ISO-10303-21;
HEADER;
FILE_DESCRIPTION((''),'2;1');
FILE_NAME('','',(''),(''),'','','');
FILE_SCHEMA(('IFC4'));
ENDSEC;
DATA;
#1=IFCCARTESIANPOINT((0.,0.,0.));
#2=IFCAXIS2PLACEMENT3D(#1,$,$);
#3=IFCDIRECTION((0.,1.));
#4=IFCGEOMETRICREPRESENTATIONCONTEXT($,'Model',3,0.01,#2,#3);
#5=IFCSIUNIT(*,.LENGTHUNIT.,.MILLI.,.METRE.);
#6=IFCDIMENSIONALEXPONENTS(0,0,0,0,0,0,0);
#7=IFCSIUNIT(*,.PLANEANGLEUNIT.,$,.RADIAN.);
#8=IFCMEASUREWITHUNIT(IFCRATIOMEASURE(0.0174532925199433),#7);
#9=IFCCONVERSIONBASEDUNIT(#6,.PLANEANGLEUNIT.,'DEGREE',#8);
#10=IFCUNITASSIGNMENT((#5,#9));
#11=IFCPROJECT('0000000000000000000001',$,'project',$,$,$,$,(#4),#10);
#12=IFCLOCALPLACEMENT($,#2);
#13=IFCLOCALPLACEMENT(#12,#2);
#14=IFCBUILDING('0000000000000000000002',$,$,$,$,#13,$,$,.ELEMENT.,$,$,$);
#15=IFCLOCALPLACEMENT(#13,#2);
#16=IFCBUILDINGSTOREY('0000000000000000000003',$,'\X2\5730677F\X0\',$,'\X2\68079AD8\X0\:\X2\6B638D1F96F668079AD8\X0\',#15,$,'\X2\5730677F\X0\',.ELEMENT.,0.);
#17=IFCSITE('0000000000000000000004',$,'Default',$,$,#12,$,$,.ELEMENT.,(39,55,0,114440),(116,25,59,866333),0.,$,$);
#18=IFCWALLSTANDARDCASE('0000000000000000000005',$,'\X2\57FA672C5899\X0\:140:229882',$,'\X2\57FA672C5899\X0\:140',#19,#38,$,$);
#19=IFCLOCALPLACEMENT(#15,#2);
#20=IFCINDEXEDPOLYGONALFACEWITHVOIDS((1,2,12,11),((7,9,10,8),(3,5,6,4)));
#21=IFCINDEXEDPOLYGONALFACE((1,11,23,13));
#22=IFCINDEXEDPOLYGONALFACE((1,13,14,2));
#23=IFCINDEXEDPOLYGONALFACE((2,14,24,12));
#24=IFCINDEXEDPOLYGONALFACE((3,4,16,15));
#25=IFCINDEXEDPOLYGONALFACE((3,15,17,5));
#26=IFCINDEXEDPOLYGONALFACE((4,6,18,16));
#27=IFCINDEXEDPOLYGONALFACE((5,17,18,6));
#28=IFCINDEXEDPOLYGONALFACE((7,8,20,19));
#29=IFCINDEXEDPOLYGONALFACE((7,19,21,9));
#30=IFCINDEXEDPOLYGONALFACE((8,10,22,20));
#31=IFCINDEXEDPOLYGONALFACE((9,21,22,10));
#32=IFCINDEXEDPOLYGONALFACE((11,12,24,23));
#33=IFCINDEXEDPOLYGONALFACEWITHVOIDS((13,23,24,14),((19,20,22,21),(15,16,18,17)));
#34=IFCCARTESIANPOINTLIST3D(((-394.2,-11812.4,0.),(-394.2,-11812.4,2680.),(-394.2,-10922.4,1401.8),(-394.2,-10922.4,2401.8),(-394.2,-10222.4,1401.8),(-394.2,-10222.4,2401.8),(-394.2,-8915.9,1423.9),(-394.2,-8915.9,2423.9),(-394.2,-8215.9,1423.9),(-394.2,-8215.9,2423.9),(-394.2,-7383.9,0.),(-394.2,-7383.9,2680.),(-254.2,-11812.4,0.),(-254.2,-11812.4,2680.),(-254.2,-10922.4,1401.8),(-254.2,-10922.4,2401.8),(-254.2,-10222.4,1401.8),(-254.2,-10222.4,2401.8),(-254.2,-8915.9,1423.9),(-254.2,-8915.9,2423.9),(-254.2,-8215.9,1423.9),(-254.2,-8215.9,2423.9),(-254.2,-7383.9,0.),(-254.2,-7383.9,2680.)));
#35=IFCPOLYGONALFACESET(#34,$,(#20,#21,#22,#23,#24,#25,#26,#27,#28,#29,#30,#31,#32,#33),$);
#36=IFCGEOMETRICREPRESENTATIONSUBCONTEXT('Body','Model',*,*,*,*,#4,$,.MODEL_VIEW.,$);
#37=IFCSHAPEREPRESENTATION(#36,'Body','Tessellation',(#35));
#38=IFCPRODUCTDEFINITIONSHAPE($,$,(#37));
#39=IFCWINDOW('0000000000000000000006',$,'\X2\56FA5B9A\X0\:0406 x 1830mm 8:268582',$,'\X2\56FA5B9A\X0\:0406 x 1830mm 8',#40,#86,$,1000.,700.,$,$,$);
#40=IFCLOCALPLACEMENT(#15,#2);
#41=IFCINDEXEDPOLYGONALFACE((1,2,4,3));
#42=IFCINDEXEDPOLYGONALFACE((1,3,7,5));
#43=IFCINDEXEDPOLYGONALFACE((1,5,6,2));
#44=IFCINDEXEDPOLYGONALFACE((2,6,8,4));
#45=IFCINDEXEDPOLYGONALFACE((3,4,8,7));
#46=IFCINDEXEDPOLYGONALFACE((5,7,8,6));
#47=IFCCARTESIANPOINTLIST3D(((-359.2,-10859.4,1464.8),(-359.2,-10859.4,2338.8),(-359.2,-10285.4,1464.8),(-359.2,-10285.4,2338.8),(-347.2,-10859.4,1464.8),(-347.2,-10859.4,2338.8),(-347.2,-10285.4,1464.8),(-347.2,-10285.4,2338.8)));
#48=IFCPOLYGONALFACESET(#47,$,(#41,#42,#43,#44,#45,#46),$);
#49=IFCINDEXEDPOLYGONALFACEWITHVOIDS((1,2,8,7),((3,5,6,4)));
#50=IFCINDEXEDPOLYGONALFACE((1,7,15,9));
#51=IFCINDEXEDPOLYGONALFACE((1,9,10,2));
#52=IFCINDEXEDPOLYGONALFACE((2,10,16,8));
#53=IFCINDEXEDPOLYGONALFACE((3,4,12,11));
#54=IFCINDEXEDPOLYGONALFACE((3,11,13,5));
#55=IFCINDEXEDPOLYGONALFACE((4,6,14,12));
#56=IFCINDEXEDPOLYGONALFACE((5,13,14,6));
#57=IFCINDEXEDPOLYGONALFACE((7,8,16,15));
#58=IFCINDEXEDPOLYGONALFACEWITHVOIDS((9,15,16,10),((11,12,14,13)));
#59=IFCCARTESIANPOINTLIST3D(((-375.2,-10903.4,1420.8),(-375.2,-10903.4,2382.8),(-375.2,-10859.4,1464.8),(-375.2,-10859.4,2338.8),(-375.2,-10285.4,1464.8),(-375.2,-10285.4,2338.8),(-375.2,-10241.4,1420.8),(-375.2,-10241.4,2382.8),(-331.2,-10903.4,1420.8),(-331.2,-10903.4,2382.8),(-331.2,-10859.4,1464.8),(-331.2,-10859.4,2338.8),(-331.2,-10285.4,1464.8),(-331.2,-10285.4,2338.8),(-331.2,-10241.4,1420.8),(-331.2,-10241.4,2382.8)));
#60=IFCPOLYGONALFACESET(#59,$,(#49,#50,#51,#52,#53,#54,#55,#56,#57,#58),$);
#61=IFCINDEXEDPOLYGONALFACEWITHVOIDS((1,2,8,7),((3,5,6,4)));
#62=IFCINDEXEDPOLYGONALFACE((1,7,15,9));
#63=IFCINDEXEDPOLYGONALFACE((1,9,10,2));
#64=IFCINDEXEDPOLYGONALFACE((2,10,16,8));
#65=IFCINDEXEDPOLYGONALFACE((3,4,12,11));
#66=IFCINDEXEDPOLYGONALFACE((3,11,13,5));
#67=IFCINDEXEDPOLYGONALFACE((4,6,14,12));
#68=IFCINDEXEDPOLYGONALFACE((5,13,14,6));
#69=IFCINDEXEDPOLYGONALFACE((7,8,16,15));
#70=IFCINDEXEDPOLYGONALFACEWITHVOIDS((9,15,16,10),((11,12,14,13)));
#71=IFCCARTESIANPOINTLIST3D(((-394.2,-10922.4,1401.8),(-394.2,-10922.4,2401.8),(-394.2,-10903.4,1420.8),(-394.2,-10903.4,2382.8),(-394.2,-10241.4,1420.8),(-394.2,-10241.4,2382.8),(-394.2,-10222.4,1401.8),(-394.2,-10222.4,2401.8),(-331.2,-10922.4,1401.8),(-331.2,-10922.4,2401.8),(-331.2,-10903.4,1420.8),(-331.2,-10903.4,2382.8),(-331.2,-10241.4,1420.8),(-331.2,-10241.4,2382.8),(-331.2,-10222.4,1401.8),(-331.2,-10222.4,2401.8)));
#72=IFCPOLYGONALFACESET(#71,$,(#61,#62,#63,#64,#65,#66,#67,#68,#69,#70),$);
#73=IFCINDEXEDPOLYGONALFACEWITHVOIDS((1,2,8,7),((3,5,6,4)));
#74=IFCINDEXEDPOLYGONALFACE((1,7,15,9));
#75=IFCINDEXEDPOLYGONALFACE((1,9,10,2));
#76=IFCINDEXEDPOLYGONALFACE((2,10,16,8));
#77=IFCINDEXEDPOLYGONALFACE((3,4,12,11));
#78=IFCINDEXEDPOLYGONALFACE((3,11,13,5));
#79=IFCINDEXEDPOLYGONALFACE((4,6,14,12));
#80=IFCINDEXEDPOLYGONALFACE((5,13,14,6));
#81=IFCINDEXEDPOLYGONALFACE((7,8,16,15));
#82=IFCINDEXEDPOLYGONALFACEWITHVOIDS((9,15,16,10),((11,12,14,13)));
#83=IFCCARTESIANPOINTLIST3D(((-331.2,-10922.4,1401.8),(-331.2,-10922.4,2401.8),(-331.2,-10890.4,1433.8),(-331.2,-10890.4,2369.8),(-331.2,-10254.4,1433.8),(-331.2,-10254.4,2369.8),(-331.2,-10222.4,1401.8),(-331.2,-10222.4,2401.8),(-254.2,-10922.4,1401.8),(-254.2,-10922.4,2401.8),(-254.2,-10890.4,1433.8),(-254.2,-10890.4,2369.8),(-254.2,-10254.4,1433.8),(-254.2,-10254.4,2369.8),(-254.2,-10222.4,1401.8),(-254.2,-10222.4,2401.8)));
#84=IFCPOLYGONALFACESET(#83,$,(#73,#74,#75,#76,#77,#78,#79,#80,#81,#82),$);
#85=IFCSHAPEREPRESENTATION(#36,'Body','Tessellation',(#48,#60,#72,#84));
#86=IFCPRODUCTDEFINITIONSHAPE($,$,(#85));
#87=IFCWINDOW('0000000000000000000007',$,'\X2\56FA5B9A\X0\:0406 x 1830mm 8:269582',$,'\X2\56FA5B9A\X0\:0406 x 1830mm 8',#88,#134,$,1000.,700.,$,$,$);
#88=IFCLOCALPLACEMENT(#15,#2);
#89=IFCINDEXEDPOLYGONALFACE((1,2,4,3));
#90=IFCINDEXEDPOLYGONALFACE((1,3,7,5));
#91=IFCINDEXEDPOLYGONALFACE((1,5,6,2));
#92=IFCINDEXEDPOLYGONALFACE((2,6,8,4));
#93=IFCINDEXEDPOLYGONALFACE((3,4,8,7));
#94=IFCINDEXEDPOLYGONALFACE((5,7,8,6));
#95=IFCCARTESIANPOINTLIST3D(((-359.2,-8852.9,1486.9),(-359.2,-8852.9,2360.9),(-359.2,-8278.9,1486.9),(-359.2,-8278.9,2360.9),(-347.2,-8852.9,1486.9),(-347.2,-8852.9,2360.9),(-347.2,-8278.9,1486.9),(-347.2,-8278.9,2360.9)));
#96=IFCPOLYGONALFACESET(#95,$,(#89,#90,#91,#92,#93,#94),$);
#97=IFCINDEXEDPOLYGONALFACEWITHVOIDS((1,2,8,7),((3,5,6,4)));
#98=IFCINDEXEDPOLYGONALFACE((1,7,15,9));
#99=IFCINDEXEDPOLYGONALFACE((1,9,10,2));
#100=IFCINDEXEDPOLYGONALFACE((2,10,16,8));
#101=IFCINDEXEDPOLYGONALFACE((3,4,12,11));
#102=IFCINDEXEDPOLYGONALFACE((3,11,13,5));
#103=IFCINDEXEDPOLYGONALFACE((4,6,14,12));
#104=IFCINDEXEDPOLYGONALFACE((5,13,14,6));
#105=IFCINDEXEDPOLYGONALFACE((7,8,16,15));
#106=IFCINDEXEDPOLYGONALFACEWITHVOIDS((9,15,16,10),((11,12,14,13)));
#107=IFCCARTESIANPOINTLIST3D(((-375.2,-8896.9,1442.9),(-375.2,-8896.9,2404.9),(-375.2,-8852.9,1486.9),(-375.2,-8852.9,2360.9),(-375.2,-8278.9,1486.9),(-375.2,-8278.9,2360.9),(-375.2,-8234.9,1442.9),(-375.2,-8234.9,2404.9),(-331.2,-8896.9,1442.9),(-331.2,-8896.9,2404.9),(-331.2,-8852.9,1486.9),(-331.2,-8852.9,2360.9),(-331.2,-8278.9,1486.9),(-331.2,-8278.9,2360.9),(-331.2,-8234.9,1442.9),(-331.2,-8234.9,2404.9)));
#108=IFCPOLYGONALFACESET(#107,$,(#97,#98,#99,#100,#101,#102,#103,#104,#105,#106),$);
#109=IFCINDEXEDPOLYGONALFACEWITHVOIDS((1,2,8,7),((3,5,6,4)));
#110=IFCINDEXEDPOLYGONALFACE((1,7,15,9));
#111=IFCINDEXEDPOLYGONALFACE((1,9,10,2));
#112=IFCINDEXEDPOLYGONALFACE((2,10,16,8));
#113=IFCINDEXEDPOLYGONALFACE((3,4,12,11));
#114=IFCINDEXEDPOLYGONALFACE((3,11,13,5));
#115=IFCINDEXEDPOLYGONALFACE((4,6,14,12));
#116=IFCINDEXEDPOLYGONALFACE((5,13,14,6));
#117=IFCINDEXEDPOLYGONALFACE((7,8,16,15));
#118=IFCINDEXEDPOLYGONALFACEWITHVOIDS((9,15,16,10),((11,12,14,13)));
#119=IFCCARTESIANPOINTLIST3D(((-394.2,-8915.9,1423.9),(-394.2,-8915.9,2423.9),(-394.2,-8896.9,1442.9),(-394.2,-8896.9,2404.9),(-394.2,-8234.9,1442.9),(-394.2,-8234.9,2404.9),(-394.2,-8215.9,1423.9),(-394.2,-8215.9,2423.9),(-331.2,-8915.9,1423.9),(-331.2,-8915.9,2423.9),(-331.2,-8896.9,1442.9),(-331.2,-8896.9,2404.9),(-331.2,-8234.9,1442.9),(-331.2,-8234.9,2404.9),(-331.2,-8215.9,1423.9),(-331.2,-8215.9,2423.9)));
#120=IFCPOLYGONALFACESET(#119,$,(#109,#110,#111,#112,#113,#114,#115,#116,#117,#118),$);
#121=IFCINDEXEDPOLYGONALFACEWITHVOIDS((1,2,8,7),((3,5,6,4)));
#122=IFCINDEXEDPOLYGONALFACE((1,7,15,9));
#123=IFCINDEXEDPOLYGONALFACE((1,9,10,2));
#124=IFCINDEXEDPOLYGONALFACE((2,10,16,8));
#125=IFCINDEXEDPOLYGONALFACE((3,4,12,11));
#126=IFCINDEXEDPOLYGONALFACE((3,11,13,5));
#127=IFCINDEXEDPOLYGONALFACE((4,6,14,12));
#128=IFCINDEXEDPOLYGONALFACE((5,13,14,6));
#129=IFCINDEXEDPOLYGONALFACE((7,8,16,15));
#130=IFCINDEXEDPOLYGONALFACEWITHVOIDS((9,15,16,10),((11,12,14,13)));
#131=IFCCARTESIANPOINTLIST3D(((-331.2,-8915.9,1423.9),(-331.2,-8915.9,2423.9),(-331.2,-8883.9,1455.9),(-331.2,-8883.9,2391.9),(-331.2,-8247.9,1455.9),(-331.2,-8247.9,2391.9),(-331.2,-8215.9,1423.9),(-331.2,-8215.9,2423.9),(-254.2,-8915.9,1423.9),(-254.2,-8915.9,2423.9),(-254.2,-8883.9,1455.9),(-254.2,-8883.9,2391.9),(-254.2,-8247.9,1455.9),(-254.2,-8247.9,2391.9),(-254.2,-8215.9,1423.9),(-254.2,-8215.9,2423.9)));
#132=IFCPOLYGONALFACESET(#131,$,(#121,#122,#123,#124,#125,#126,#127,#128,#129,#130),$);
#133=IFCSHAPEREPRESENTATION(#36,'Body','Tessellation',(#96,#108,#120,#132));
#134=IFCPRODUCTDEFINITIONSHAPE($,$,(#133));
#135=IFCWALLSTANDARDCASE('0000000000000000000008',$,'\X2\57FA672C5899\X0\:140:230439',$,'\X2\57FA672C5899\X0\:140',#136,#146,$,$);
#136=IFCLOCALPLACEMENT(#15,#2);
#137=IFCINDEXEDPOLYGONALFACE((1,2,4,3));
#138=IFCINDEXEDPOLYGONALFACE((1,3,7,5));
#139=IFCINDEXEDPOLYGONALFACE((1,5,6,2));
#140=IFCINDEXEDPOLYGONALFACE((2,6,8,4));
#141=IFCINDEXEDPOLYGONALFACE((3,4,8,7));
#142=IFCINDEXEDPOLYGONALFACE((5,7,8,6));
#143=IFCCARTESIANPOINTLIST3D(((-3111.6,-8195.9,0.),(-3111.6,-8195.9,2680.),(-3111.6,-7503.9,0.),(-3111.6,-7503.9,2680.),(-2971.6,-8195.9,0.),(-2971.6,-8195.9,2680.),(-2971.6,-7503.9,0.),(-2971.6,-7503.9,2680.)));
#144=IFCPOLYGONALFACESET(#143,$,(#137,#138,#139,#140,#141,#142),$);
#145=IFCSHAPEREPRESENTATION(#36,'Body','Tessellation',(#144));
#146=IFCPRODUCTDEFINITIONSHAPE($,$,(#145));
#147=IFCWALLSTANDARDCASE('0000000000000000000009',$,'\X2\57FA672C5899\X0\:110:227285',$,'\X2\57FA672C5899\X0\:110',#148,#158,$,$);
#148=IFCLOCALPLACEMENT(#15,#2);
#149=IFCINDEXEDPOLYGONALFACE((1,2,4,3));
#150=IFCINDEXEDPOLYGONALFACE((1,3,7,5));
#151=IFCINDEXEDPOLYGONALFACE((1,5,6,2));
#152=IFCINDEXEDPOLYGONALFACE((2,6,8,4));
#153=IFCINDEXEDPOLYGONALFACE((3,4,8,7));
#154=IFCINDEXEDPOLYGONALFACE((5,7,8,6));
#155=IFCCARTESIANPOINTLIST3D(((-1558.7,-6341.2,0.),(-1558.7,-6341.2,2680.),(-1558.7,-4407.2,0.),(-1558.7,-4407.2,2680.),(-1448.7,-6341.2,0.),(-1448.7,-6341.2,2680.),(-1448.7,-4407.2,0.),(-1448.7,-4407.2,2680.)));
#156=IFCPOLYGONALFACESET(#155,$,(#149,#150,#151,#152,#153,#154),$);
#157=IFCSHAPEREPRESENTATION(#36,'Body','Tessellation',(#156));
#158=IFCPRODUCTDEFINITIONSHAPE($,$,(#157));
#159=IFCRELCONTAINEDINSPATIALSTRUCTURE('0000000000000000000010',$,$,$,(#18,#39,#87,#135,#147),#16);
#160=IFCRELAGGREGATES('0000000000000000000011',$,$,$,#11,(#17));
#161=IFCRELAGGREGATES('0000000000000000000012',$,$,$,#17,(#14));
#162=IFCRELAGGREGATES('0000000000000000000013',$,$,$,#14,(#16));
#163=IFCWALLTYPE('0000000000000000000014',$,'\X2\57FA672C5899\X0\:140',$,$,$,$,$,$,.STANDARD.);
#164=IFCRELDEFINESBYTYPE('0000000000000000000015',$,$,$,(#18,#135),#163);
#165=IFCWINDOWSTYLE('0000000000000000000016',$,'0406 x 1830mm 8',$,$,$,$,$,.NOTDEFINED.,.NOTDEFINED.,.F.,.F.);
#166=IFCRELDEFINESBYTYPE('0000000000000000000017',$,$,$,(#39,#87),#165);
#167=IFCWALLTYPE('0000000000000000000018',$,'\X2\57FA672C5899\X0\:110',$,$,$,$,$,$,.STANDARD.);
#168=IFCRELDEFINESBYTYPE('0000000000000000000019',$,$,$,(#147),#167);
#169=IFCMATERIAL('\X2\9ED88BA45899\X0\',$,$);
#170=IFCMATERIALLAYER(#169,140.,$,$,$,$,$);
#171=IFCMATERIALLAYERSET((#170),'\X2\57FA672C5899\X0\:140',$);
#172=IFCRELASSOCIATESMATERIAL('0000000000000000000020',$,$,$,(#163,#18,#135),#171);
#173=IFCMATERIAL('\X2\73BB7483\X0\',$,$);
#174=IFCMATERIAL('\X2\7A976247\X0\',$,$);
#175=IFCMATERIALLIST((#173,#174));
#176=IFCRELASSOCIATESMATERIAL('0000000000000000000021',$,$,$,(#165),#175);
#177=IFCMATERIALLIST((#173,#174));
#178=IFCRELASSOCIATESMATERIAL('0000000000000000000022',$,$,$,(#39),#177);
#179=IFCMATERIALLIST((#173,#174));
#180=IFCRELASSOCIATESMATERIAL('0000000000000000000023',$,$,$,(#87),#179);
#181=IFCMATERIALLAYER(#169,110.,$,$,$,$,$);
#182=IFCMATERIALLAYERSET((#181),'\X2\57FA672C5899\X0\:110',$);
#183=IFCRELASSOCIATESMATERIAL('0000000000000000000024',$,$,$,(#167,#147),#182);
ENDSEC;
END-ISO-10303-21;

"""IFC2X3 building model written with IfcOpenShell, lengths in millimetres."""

from ifc_helpers import new_model, entity, si_unit, converted_unit, direction, frame, frame_2d, origin, origin_2d_with_axis, place, context, subcontext, project, spatial, polyline, rectangle, outline, extrude, source, transform, mapped, material, material_list, layer, layer_set, layer_usage, type_object, type_shapes, element, fill, save


model = new_model("IFC2X3")

# Units and contexts
model_context = context("Model", 3, precision=0.01, world=origin(), true_north=direction((0.0, 1.0)))
body_context = subcontext(model_context, "Body", "Model", "MODEL_VIEW")
ifc_project = project(units=[si_unit("LENGTHUNIT", "METRE", prefix="MILLI"), converted_unit("PLANEANGLEUNIT", "DEGREE", entity("IfcRatioMeasure", 0.0174532925199433), si_unit("PLANEANGLEUNIT", "RADIAN"), dimensions=[0, 0, 0, 0, 0, 0, 0])], contexts=[model_context])

# Site, building, storey
site_placement = place(None, origin())
site = spatial("IfcSite", under=ifc_project, at=site_placement, Name="Default", CompositionType="ELEMENT", RefLatitude=(39, 55, 0, 114440), RefLongitude=(116, 25, 59, 866333), RefElevation=0.0)
building_placement = place(site_placement, origin())
building = spatial("IfcBuilding", under=site, at=building_placement, CompositionType="ELEMENT")
storey_placement = place(building_placement, origin())
storey = spatial("IfcBuildingStorey", under=building, at=storey_placement, Name="地板", ObjectType="标高:正负零标高", LongName="地板", CompositionType="ELEMENT", Elevation=0.0)

# Shared definitions
ifc_material_1 = material(Name="默认墙")

# Shared definitions
ifc_material_2 = material(Name="玻璃")
ifc_material_3 = material(Name="窗扇")

# Shared definitions
ifc_layer_1 = layer(ifc_material_1, 140.0)
ifc_layer_set_1 = layer_set([ifc_layer_1], Name="基本墙:140")
wall_type_1 = type_object("IfcWallType", Name="基本墙:140", PredefinedType="STANDARD", material=ifc_layer_set_1)

# Wall, openings, windows
ifc_layer_usage_1 = layer_usage(ifc_layer_set_1, "AXIS2", "NEGATIVE", 70.0)
wall_1_placement = place(storey_placement, frame((-324.2, -11812.4, 0.0), z_axis=(0.0, 0.0, 1.0), x_axis=(0.0, 1.0, 0.0)))
wall_1 = element("IfcWallStandardCase", 1, at=wall_1_placement, inside=storey, type_object=wall_type_1, material=ifc_layer_usage_1, Name="基本墙:140:229882", ObjectType="基本墙:140", context=body_context, shape_type="SweptSolid", body=[
    extrude(rectangle(XDim=4428.5, YDim=140.0, at=frame_2d((2214.3, 0.0), x_axis=(-1.0, 0.0))), origin(), (0.0, 0.0, 1.0), 2680.0),
])
opening_1_placement = place(wall_1_placement, frame((890.0, -70.0, 1401.8)))
opening_1 = element("IfcOpeningElement", 2, at=opening_1_placement, cuts=wall_1, ObjectType="Opening", context=body_context, shape_type="SweptSolid", body=[
    extrude(rectangle(XDim=1000.0, YDim=700.0, at=frame_2d((500.0, 350.0), x_axis=(1.0, 0.0))), frame((0.0, 0.0, 0.0), z_axis=(0.0, 1.0, 0.0), x_axis=(0.0, 0.0, 1.0)), (0.0, 0.0, 1.0), 140.0),
])
opening_2_placement = place(wall_1_placement, frame((2896.5, -70.0, 1423.9)))
opening_2 = element("IfcOpeningElement", 3, at=opening_2_placement, cuts=wall_1, ObjectType="Opening", context=body_context, shape_type="SweptSolid", body=[
    extrude(rectangle(XDim=1000.0, YDim=700.0, at=frame_2d((500.0, 350.0), x_axis=(1.0, 0.0))), frame((0.0, 0.0, 0.0), z_axis=(0.0, 1.0, 0.0), x_axis=(0.0, 0.0, 1.0)), (0.0, 0.0, 1.0), 140.0),
])
ifc_material_list_1 = material_list([ifc_material_2, ifc_material_3])
ifc_material_list_2 = material_list([ifc_material_2, ifc_material_3])
window_style_1 = type_object("IfcWindowStyle", Name="0406 x 1830mm 8", ConstructionType="NOTDEFINED", OperationType="NOTDEFINED", ParameterTakesPrecedence=False, Sizeable=False, material=ifc_material_list_2)
shared_shape_1 = source(origin(), body_context, "Body", "SweptSolid", [
    extrude(rectangle(XDim=12.0, YDim=574.0, at=origin_2d_with_axis()), frame((350.0, 99.0, 63.0), z_axis=(0.0, 0.0, 1.0), x_axis=(0.0, -1.0, 0.0)), (0.0, 0.0, 1.0), 874.0),
    extrude(outline(polyline([(-331.0, -481.0), (331.0, -481.0), (331.0, 481.0), (-331.0, 481.0), (-331.0, -481.0)]), holes=[polyline([(-287.0, -437.0), (-287.0, 437.0), (287.0, 437.0), (287.0, -437.0), (-287.0, -437.0)])]), frame((350.0, 77.0, 500.0), z_axis=(0.0, 1.0, 0.0), x_axis=(1.0, 0.0, 0.0)), (0.0, 0.0, 1.0), 44.0),
    extrude(outline(polyline([(-350.0, -500.0), (350.0, -500.0), (350.0, 500.0), (-350.0, 500.0), (-350.0, -500.0)]), holes=[polyline([(-331.0, -481.0), (-331.0, 481.0), (331.0, 481.0), (331.0, -481.0), (-331.0, -481.0)])]), frame((350.0, 77.0, 500.0), z_axis=(0.0, 1.0, 0.0), x_axis=(1.0, 0.0, 0.0)), (0.0, 0.0, 1.0), 63.0),
    extrude(outline(polyline([(-350.0, -500.0), (350.0, -500.0), (350.0, 500.0), (-350.0, 500.0), (-350.0, -500.0)]), holes=[polyline([(-318.0, -468.0), (-318.0, 468.0), (318.0, 468.0), (318.0, -468.0), (-318.0, -468.0)])]), frame((350.0, 0.0, 500.0), z_axis=(0.0, 1.0, 0.0), x_axis=(1.0, 0.0, 0.0)), (0.0, 0.0, 1.0), 77.0),
])
type_shapes(window_style_1, [shared_shape_1])
window_1_placement = place(opening_1_placement, origin())
window_1 = element("IfcWindow", 4, at=window_1_placement, inside=storey, type_object=window_style_1, material=ifc_material_list_1, Name="固定:0406 x 1830mm 8:268582", ObjectType="固定:0406 x 1830mm 8", OverallHeight=1000.0, OverallWidth=700.0, context=body_context, shape_type="MappedRepresentation", body=[
    mapped(shared_shape_1, transform((0.0, 0.0, 0.0), scale=1.0)),
])
fill(opening_1, window_1)
ifc_material_list_3 = material_list([ifc_material_2, ifc_material_3])
window_2_placement = place(opening_2_placement, origin())
window_2 = element("IfcWindow", 5, at=window_2_placement, inside=storey, type_object=window_style_1, material=ifc_material_list_3, Name="固定:0406 x 1830mm 8:269582", ObjectType="固定:0406 x 1830mm 8", OverallHeight=1000.0, OverallWidth=700.0, context=body_context, shape_type="MappedRepresentation", body=[
    mapped(shared_shape_1, transform((0.0, 0.0, 0.0), scale=1.0)),
])
fill(opening_2, window_2)

# Walls
ifc_layer_usage_2 = layer_usage(ifc_layer_set_1, "AXIS2", "NEGATIVE", 70.0)
wall_2_placement = place(storey_placement, frame((-3041.6, -7503.9, 0.0), z_axis=(0.0, 0.0, 1.0), x_axis=(0.0, -1.0, 0.0)))
element("IfcWallStandardCase", 6, at=wall_2_placement, inside=storey, type_object=wall_type_1, material=ifc_layer_usage_2, Name="基本墙:140:230439", ObjectType="基本墙:140", context=body_context, shape_type="SweptSolid", body=[
    extrude(rectangle(XDim=692.0, YDim=140.0, at=frame_2d((346.0, 0.0), x_axis=(-1.0, 0.0))), origin(), (0.0, 0.0, 1.0), 2680.0),
])
ifc_layer_2 = layer(ifc_material_1, 110.0)
ifc_layer_set_2 = layer_set([ifc_layer_2], Name="基本墙:110")
ifc_layer_usage_3 = layer_usage(ifc_layer_set_2, "AXIS2", "NEGATIVE", 55.0)
wall_type_2 = type_object("IfcWallType", Name="基本墙:110", PredefinedType="STANDARD", material=ifc_layer_set_2)
wall_3_placement = place(storey_placement, frame((-1503.7, -4407.2, 0.0), z_axis=(0.0, 0.0, 1.0), x_axis=(0.0, -1.0, 0.0)))
element("IfcWallStandardCase", 7, at=wall_3_placement, inside=storey, type_object=wall_type_2, material=ifc_layer_usage_3, Name="基本墙:110:227285", ObjectType="基本墙:110", context=body_context, shape_type="SweptSolid", body=[
    extrude(rectangle(XDim=1934.0, YDim=110.0, at=frame_2d((967.0, 0.0), x_axis=(-1.0, 0.0))), origin(), (0.0, 0.0, 1.0), 2680.0),
])

save(model, "model.ifc")
